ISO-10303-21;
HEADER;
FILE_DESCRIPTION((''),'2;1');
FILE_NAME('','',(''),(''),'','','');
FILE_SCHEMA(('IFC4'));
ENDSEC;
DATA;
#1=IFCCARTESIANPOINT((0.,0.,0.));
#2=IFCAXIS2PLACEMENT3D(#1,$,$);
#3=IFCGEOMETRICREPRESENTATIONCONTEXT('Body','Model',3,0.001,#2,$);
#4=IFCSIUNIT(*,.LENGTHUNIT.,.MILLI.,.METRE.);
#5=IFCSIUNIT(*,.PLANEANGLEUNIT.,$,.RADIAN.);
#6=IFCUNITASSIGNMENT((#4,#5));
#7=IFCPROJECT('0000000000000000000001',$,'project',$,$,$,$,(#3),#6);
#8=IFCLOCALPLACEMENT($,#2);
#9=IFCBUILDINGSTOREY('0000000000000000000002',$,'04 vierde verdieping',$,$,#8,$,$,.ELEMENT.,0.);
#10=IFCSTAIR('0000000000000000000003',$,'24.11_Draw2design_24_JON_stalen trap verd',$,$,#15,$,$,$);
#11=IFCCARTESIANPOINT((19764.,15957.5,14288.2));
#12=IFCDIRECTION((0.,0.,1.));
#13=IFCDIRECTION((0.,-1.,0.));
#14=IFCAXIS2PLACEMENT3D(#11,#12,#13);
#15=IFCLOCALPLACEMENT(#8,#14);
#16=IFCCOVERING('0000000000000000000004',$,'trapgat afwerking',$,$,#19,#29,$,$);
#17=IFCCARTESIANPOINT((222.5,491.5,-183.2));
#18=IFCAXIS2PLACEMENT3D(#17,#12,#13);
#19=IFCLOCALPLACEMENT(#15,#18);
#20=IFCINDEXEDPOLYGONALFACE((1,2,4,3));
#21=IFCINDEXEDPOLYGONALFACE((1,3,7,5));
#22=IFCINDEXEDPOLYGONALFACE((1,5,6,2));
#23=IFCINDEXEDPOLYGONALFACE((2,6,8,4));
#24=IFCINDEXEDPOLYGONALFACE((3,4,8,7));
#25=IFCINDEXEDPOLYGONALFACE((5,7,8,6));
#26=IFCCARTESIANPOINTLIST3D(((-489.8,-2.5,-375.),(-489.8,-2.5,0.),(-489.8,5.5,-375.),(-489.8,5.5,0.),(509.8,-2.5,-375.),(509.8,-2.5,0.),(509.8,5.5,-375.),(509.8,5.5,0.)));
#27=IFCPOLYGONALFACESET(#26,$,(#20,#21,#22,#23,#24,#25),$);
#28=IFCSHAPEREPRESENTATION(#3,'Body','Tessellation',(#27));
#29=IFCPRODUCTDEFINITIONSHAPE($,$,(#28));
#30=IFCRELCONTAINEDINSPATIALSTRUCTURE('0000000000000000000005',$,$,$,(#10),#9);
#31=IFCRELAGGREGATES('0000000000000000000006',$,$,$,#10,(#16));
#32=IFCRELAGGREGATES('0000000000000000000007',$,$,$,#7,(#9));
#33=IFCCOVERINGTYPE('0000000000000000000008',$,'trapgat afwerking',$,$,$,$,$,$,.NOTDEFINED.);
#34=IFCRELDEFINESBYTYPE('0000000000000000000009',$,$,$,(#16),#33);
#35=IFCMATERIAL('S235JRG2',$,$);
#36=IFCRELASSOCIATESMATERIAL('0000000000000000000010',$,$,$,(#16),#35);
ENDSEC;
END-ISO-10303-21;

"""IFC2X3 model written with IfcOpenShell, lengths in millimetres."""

from ifc_helpers import new_model, si_unit, frame, origin, place, context, project, spatial, polyline, outline, extrude, source, transform, mapped, material, type_object, element, aggregate, save


model = new_model("IFC2X3")

# Units and contexts
model_context = context("Model", 3, precision=0.001, world=origin(), identifier="Body")
ifc_project = project(units=[si_unit("LENGTHUNIT", "METRE", prefix="MILLI"), si_unit("PLANEANGLEUNIT", "RADIAN")], contexts=[model_context])

# Storey
storey_placement = place(None, origin())
storey = spatial("IfcBuildingStorey", under=ifc_project, at=storey_placement, Name="04 vierde verdieping", CompositionType="ELEMENT", Elevation=0.0)

# Stair
stair_placement = place(storey_placement, frame((19764.0, 15957.5, 14288.2), z_axis=(0.0, 0.0, 1.0), x_axis=(0.0, -1.0, 0.0)))
stair = element("IfcStair", 1, at=stair_placement, inside=storey, Name="24.11_Draw2design_24_JON_stalen trap verd")
ifc_material_1 = material(Name="S235JRG2")

# Covering
covering_type = type_object("IfcCoveringType", Name="trapgat afwerking")
shared_shape_1 = source(origin(), model_context, "Body", "SweptSolid", [
    extrude(outline(polyline([(-489.8, -2.5), (509.8, -2.5), (509.8, 5.5), (-489.8, 5.5), (-489.8, -2.5)])), origin(), (0.0, 0.0, -1.0), 375.0),
])
covering_placement = place(stair_placement, frame((222.5, 491.5, -183.2), z_axis=(0.0, 0.0, 1.0), x_axis=(0.0, -1.0, 0.0)))
covering = element("IfcCovering", 2, at=covering_placement, type_object=covering_type, material=ifc_material_1, Name="trapgat afwerking", context=model_context, shape_type="MappedRepresentation", body=[
    mapped(shared_shape_1, transform((0.0, 0.0, 0.0), scale=1.0)),
])
aggregate(stair, [covering])

save(model, "model.ifc")
